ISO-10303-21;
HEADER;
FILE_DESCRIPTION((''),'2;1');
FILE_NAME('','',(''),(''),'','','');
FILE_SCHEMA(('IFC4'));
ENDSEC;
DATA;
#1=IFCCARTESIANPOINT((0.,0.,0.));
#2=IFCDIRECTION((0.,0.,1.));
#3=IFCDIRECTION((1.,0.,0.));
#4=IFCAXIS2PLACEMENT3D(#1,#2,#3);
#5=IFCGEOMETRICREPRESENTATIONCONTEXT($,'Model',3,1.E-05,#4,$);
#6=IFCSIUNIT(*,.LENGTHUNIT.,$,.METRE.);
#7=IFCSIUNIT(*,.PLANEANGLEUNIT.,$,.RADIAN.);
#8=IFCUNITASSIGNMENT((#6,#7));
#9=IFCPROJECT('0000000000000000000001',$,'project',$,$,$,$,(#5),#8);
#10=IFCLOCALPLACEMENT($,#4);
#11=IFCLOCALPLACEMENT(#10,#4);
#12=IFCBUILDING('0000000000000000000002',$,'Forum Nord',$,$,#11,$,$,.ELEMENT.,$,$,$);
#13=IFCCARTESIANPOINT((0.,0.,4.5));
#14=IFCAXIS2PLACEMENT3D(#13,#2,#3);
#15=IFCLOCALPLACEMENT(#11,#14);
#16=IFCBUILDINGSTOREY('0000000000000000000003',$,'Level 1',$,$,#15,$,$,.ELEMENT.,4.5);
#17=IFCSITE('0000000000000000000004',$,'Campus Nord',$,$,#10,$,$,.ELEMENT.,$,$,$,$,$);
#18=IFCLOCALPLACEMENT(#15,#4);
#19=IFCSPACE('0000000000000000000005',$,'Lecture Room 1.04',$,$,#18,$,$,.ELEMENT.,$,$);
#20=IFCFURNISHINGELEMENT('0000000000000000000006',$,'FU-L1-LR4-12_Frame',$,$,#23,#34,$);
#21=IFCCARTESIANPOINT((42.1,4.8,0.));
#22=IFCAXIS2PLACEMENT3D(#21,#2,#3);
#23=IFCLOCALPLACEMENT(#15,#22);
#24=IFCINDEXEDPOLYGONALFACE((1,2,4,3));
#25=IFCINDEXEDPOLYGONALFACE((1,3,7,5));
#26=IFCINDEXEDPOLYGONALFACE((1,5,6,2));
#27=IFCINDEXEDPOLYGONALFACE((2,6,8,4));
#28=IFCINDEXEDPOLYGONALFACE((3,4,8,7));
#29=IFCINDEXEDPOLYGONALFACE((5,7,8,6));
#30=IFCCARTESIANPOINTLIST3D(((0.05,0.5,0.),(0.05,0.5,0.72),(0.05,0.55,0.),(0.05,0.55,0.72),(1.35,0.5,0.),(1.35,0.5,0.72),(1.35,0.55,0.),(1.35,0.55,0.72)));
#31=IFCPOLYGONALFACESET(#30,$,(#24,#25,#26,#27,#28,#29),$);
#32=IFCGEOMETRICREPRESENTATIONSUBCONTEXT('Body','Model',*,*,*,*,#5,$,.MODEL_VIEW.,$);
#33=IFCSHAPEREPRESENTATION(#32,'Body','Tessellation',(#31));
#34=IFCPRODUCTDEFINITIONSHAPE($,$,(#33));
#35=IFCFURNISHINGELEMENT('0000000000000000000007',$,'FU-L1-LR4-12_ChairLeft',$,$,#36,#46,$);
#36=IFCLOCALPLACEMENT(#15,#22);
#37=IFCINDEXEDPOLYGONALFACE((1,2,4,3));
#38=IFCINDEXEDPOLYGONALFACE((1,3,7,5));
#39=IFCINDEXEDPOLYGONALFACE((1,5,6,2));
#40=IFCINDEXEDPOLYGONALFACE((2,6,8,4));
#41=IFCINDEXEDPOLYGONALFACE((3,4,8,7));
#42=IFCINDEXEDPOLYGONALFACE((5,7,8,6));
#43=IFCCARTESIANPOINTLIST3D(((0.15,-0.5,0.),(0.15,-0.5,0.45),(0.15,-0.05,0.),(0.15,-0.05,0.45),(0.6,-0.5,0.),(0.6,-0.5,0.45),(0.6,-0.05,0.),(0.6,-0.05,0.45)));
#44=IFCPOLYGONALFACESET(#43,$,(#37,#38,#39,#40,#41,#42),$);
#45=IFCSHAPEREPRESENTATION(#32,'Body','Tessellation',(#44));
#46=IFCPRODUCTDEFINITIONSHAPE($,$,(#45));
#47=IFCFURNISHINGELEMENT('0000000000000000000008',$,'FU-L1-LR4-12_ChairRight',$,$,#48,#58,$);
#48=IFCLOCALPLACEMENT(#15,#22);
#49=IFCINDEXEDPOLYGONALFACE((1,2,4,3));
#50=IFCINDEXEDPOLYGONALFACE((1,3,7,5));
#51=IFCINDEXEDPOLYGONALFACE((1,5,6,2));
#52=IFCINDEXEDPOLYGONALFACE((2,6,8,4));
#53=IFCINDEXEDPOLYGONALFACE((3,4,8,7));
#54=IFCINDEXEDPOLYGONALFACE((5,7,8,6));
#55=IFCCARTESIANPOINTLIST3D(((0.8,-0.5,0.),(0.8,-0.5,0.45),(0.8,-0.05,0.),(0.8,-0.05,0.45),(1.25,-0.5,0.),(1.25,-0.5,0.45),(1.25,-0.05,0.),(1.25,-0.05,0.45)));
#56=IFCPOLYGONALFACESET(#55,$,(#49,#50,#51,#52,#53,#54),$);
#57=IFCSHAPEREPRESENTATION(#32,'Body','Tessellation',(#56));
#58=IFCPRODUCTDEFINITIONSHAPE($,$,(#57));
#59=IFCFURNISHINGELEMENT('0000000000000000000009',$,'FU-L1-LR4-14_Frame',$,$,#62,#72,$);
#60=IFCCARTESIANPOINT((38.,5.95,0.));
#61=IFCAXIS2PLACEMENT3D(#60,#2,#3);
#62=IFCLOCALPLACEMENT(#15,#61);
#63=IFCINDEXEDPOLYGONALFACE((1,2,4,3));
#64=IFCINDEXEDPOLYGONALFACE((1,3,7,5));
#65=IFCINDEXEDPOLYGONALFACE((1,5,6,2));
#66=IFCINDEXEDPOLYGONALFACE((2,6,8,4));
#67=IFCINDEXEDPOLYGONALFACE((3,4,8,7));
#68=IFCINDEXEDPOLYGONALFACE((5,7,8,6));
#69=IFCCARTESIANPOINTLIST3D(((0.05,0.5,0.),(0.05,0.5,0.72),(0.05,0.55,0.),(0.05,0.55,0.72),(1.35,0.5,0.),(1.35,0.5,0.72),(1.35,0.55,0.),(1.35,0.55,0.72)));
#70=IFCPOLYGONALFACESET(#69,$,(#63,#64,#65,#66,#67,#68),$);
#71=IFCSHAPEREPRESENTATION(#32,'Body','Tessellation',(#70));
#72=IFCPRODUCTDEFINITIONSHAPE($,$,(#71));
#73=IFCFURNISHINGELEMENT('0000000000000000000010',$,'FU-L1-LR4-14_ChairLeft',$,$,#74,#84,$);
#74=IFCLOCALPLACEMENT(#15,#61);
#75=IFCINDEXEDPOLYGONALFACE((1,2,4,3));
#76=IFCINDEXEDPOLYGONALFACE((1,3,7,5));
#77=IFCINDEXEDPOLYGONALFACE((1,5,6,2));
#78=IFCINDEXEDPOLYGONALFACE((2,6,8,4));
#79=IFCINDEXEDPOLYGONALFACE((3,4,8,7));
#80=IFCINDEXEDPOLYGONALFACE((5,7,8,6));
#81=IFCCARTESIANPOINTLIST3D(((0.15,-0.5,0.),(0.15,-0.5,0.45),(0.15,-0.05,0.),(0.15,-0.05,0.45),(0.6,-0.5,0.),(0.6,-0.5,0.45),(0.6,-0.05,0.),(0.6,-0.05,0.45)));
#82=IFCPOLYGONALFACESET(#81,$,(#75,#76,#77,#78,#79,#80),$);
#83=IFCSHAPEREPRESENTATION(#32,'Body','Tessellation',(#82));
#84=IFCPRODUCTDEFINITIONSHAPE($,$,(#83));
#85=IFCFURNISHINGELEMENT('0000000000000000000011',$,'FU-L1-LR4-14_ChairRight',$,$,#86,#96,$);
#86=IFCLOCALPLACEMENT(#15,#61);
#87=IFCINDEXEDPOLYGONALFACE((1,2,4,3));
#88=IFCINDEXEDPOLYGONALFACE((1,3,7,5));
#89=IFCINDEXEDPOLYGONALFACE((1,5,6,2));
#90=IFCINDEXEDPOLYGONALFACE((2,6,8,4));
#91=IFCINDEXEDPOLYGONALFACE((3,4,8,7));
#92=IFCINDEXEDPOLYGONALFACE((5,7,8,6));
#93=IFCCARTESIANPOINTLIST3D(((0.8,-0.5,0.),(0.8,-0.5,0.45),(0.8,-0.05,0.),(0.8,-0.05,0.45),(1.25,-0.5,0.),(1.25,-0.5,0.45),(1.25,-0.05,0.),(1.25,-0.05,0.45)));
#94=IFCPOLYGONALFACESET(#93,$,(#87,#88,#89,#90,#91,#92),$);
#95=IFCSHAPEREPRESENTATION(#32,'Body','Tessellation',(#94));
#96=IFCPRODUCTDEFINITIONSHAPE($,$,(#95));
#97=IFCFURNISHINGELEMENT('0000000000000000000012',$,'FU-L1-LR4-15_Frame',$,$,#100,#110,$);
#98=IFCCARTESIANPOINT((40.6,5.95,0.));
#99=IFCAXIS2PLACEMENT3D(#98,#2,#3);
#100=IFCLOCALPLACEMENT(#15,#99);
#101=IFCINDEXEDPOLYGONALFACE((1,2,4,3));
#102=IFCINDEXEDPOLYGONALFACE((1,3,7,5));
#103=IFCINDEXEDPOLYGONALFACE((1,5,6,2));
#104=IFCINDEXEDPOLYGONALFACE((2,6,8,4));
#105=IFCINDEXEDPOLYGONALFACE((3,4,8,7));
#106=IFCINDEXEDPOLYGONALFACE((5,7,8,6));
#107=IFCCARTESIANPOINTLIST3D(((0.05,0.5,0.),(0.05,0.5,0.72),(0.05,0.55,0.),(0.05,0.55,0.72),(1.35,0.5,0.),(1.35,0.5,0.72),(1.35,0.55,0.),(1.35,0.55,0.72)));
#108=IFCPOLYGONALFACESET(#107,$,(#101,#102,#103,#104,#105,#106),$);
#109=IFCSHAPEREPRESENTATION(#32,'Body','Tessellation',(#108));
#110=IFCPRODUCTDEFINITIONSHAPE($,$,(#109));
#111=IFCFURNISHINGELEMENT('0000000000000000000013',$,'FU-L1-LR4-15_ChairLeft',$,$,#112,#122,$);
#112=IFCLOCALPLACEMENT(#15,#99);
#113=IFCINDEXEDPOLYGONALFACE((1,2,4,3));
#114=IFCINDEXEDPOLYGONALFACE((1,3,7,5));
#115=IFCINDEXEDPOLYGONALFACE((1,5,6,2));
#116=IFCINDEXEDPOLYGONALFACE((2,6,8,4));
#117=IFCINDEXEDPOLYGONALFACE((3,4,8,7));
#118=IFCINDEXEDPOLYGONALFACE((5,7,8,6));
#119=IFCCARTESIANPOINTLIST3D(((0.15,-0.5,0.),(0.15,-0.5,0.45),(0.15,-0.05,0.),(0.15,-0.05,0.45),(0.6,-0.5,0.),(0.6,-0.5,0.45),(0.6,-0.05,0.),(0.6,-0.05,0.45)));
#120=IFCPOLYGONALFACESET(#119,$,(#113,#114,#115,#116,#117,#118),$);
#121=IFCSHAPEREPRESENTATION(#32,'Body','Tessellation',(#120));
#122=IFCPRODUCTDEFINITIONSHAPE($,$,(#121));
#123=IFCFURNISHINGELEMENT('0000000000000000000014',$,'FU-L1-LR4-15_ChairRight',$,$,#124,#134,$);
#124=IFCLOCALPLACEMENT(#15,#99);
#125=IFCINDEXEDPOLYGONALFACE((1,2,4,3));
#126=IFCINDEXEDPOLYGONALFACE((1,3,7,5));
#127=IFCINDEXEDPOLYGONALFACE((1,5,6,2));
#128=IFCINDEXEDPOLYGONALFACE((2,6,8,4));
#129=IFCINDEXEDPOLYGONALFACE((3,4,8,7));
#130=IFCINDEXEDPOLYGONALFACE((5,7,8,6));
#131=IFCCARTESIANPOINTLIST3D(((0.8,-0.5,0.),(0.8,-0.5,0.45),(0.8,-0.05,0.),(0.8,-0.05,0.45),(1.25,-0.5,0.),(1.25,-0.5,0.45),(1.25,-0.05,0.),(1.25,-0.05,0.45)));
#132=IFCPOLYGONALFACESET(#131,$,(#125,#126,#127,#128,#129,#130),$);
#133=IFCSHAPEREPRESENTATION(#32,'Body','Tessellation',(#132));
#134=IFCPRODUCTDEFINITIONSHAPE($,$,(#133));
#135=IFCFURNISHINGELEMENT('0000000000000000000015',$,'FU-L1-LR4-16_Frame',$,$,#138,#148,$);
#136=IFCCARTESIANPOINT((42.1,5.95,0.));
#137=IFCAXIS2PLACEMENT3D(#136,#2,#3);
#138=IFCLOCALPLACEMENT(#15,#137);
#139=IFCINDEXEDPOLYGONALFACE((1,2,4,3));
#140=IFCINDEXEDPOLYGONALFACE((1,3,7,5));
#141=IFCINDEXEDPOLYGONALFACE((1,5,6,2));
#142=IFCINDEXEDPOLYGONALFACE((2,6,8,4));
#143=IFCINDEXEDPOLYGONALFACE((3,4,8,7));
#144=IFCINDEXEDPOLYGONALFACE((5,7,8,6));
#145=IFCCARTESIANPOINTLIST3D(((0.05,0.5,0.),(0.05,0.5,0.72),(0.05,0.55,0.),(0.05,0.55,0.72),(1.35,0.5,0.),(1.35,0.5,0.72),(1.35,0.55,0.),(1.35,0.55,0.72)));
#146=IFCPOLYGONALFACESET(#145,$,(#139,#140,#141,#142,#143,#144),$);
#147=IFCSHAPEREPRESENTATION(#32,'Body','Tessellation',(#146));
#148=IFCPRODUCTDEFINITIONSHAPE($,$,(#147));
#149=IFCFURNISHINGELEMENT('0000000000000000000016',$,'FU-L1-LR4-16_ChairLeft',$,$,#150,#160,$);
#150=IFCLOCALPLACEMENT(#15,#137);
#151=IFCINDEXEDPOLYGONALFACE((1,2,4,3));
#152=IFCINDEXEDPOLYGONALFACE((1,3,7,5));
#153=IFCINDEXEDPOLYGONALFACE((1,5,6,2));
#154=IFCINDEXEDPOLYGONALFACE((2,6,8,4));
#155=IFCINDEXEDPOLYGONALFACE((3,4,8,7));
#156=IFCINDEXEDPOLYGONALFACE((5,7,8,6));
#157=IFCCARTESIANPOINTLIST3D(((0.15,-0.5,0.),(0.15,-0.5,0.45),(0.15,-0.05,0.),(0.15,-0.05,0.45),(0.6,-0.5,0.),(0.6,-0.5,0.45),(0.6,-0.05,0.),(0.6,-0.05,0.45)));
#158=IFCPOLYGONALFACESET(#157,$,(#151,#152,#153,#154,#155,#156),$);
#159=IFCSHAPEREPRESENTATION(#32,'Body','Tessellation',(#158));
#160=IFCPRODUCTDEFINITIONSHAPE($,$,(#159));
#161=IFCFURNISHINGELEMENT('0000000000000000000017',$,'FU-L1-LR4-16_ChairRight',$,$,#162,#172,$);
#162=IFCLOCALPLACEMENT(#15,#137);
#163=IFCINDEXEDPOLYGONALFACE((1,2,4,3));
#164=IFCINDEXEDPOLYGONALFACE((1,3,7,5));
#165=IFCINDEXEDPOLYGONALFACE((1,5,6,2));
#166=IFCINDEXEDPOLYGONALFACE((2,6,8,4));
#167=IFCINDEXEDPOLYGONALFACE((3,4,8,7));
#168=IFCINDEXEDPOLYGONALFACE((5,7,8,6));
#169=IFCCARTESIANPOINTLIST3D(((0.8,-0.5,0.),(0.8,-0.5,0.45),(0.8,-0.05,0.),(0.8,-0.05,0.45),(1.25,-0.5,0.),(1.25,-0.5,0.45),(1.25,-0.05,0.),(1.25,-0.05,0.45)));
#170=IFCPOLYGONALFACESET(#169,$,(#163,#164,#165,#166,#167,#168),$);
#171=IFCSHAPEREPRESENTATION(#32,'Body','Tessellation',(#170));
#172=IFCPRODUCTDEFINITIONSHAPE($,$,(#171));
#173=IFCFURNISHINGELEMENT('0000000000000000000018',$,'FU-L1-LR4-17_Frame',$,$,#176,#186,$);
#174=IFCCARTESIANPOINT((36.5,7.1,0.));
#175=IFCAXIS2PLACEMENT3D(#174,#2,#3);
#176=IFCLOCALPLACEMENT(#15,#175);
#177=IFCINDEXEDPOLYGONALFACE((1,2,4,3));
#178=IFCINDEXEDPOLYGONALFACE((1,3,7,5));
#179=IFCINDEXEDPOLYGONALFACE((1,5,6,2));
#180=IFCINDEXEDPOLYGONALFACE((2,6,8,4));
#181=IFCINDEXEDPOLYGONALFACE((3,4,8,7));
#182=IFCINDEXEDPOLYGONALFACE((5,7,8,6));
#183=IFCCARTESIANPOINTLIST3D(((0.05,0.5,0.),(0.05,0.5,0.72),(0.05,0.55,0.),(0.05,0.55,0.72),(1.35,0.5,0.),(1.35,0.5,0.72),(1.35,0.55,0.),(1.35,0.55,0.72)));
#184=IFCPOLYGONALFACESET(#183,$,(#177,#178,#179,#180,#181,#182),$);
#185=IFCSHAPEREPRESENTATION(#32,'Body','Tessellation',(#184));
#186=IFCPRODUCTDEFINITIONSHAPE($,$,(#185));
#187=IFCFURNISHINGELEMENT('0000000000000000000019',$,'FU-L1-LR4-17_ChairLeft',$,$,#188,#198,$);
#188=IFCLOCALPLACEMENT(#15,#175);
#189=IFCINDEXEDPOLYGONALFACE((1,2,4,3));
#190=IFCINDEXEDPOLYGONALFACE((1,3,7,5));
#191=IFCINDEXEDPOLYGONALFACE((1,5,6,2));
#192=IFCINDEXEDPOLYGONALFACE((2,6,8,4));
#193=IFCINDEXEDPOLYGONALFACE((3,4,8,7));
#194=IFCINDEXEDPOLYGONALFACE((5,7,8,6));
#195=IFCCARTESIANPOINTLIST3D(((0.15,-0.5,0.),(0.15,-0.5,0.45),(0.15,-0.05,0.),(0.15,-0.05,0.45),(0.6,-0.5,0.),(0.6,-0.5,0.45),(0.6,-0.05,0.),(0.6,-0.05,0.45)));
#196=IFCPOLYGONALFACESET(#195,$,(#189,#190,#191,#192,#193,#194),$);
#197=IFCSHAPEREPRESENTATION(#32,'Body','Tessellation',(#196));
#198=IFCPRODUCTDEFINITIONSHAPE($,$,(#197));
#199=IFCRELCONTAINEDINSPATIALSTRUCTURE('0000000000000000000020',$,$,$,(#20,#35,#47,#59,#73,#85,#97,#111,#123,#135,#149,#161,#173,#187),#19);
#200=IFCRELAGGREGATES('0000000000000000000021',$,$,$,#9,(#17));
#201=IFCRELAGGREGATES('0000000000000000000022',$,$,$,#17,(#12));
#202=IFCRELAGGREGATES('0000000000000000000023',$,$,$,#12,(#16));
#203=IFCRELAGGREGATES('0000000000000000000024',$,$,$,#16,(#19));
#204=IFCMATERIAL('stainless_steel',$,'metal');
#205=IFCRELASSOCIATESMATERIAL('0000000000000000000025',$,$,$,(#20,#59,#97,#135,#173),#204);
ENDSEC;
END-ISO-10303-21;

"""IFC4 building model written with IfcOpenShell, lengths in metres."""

from ifc_helpers import new_model, si_unit, frame, frame_2d, origin_with_axes, place, context, subcontext, project, spatial, rectangle, extrude, material, element, save


model = new_model("IFC4")

# Units and contexts
model_context = context("Model", 3, precision=1e-05, world=origin_with_axes())
body_context = subcontext(model_context, "Body", "Model", "MODEL_VIEW")
ifc_project = project(units=[si_unit("LENGTHUNIT", "METRE"), si_unit("PLANEANGLEUNIT", "RADIAN")], contexts=[model_context])

# Site, building, storey, space
site_placement = place(None, origin_with_axes())
site = spatial("IfcSite", under=ifc_project, at=site_placement, Name="Campus Nord", CompositionType="ELEMENT")
building_placement = place(site_placement, origin_with_axes())
building = spatial("IfcBuilding", under=site, at=building_placement, Name="Forum Nord", CompositionType="ELEMENT")
storey_placement = place(building_placement, frame((0.0, 0.0, 4.5), z_axis=(0.0, 0.0, 1.0), x_axis=(1.0, 0.0, 0.0)))
storey = spatial("IfcBuildingStorey", under=building, at=storey_placement, Name="Level 1", CompositionType="ELEMENT", Elevation=4.5)
space_placement = place(storey_placement, origin_with_axes())
space = spatial("IfcSpace", under=storey, at=space_placement, Name="Lecture Room 1.04", CompositionType="ELEMENT")

# Furnishing elements
ifc_material_1 = material(Name="stainless_steel", Category="metal")
furnishing_1_placement = place(storey_placement, frame((42.1, 4.8, 0.0), z_axis=(0.0, 0.0, 1.0), x_axis=(1.0, 0.0, 0.0)))
element("IfcFurnishingElement", 1, at=furnishing_1_placement, inside=space, material=ifc_material_1, Name="FU-L1-LR4-12_Frame", context=body_context, shape_type="SweptSolid", body=[
    extrude(rectangle(XDim=1.3, YDim=0.05, at=frame_2d((0.7, 0.525), x_axis=(1.0, 0.0))), origin_with_axes(), (0.0, 0.0, 1.0), 0.72),
])
furnishing_2_placement = place(storey_placement, frame((42.1, 4.8, 0.0), z_axis=(0.0, 0.0, 1.0), x_axis=(1.0, 0.0, 0.0)))
element("IfcFurnishingElement", 2, at=furnishing_2_placement, inside=space, Name="FU-L1-LR4-12_ChairLeft", context=body_context, shape_type="SweptSolid", body=[
    extrude(rectangle(XDim=0.45, YDim=0.45, at=frame_2d((0.375, -0.275), x_axis=(1.0, 0.0))), origin_with_axes(), (0.0, 0.0, 1.0), 0.45),
])
furnishing_3_placement = place(storey_placement, frame((42.1, 4.8, 0.0), z_axis=(0.0, 0.0, 1.0), x_axis=(1.0, 0.0, 0.0)))
element("IfcFurnishingElement", 3, at=furnishing_3_placement, inside=space, Name="FU-L1-LR4-12_ChairRight", context=body_context, shape_type="SweptSolid", body=[
    extrude(rectangle(XDim=0.45, YDim=0.45, at=frame_2d((1.025, -0.275), x_axis=(1.0, 0.0))), origin_with_axes(), (0.0, 0.0, 1.0), 0.45),
])
furnishing_4_placement = place(storey_placement, frame((38.0, 5.95, 0.0), z_axis=(0.0, 0.0, 1.0), x_axis=(1.0, 0.0, 0.0)))
element("IfcFurnishingElement", 4, at=furnishing_4_placement, inside=space, material=ifc_material_1, Name="FU-L1-LR4-14_Frame", context=body_context, shape_type="SweptSolid", body=[
    extrude(rectangle(XDim=1.3, YDim=0.05, at=frame_2d((0.7, 0.525), x_axis=(1.0, 0.0))), origin_with_axes(), (0.0, 0.0, 1.0), 0.72),
])
furnishing_5_placement = place(storey_placement, frame((38.0, 5.95, 0.0), z_axis=(0.0, 0.0, 1.0), x_axis=(1.0, 0.0, 0.0)))
element("IfcFurnishingElement", 5, at=furnishing_5_placement, inside=space, Name="FU-L1-LR4-14_ChairLeft", context=body_context, shape_type="SweptSolid", body=[
    extrude(rectangle(XDim=0.45, YDim=0.45, at=frame_2d((0.375, -0.275), x_axis=(1.0, 0.0))), origin_with_axes(), (0.0, 0.0, 1.0), 0.45),
])
furnishing_6_placement = place(storey_placement, frame((38.0, 5.95, 0.0), z_axis=(0.0, 0.0, 1.0), x_axis=(1.0, 0.0, 0.0)))
element("IfcFurnishingElement", 6, at=furnishing_6_placement, inside=space, Name="FU-L1-LR4-14_ChairRight", context=body_context, shape_type="SweptSolid", body=[
    extrude(rectangle(XDim=0.45, YDim=0.45, at=frame_2d((1.025, -0.275), x_axis=(1.0, 0.0))), origin_with_axes(), (0.0, 0.0, 1.0), 0.45),
])
furnishing_7_placement = place(storey_placement, frame((40.6, 5.95, 0.0), z_axis=(0.0, 0.0, 1.0), x_axis=(1.0, 0.0, 0.0)))
element("IfcFurnishingElement", 7, at=furnishing_7_placement, inside=space, material=ifc_material_1, Name="FU-L1-LR4-15_Frame", context=body_context, shape_type="SweptSolid", body=[
    extrude(rectangle(XDim=1.3, YDim=0.05, at=frame_2d((0.7, 0.525), x_axis=(1.0, 0.0))), origin_with_axes(), (0.0, 0.0, 1.0), 0.72),
])
furnishing_8_placement = place(storey_placement, frame((40.6, 5.95, 0.0), z_axis=(0.0, 0.0, 1.0), x_axis=(1.0, 0.0, 0.0)))
element("IfcFurnishingElement", 8, at=furnishing_8_placement, inside=space, Name="FU-L1-LR4-15_ChairLeft", context=body_context, shape_type="SweptSolid", body=[
    extrude(rectangle(XDim=0.45, YDim=0.45, at=frame_2d((0.375, -0.275), x_axis=(1.0, 0.0))), origin_with_axes(), (0.0, 0.0, 1.0), 0.45),
])
furnishing_9_placement = place(storey_placement, frame((40.6, 5.95, 0.0), z_axis=(0.0, 0.0, 1.0), x_axis=(1.0, 0.0, 0.0)))
element("IfcFurnishingElement", 9, at=furnishing_9_placement, inside=space, Name="FU-L1-LR4-15_ChairRight", context=body_context, shape_type="SweptSolid", body=[
    extrude(rectangle(XDim=0.45, YDim=0.45, at=frame_2d((1.025, -0.275), x_axis=(1.0, 0.0))), origin_with_axes(), (0.0, 0.0, 1.0), 0.45),
])
furnishing_10_placement = place(storey_placement, frame((42.1, 5.95, 0.0), z_axis=(0.0, 0.0, 1.0), x_axis=(1.0, 0.0, 0.0)))
element("IfcFurnishingElement", 10, at=furnishing_10_placement, inside=space, material=ifc_material_1, Name="FU-L1-LR4-16_Frame", context=body_context, shape_type="SweptSolid", body=[
    extrude(rectangle(XDim=1.3, YDim=0.05, at=frame_2d((0.7, 0.525), x_axis=(1.0, 0.0))), origin_with_axes(), (0.0, 0.0, 1.0), 0.72),
])
furnishing_11_placement = place(storey_placement, frame((42.1, 5.95, 0.0), z_axis=(0.0, 0.0, 1.0), x_axis=(1.0, 0.0, 0.0)))
element("IfcFurnishingElement", 11, at=furnishing_11_placement, inside=space, Name="FU-L1-LR4-16_ChairLeft", context=body_context, shape_type="SweptSolid", body=[
    extrude(rectangle(XDim=0.45, YDim=0.45, at=frame_2d((0.375, -0.275), x_axis=(1.0, 0.0))), origin_with_axes(), (0.0, 0.0, 1.0), 0.45),
])
furnishing_12_placement = place(storey_placement, frame((42.1, 5.95, 0.0), z_axis=(0.0, 0.0, 1.0), x_axis=(1.0, 0.0, 0.0)))
element("IfcFurnishingElement", 12, at=furnishing_12_placement, inside=space, Name="FU-L1-LR4-16_ChairRight", context=body_context, shape_type="SweptSolid", body=[
    extrude(rectangle(XDim=0.45, YDim=0.45, at=frame_2d((1.025, -0.275), x_axis=(1.0, 0.0))), origin_with_axes(), (0.0, 0.0, 1.0), 0.45),
])
furnishing_13_placement = place(storey_placement, frame((36.5, 7.1, 0.0), z_axis=(0.0, 0.0, 1.0), x_axis=(1.0, 0.0, 0.0)))
element("IfcFurnishingElement", 13, at=furnishing_13_placement, inside=space, material=ifc_material_1, Name="FU-L1-LR4-17_Frame", context=body_context, shape_type="SweptSolid", body=[
    extrude(rectangle(XDim=1.3, YDim=0.05, at=frame_2d((0.7, 0.525), x_axis=(1.0, 0.0))), origin_with_axes(), (0.0, 0.0, 1.0), 0.72),
])
furnishing_14_placement = place(storey_placement, frame((36.5, 7.1, 0.0), z_axis=(0.0, 0.0, 1.0), x_axis=(1.0, 0.0, 0.0)))
element("IfcFurnishingElement", 14, at=furnishing_14_placement, inside=space, Name="FU-L1-LR4-17_ChairLeft", context=body_context, shape_type="SweptSolid", body=[
    extrude(rectangle(XDim=0.45, YDim=0.45, at=frame_2d((0.375, -0.275), x_axis=(1.0, 0.0))), origin_with_axes(), (0.0, 0.0, 1.0), 0.45),
])

save(model, "model.ifc")
